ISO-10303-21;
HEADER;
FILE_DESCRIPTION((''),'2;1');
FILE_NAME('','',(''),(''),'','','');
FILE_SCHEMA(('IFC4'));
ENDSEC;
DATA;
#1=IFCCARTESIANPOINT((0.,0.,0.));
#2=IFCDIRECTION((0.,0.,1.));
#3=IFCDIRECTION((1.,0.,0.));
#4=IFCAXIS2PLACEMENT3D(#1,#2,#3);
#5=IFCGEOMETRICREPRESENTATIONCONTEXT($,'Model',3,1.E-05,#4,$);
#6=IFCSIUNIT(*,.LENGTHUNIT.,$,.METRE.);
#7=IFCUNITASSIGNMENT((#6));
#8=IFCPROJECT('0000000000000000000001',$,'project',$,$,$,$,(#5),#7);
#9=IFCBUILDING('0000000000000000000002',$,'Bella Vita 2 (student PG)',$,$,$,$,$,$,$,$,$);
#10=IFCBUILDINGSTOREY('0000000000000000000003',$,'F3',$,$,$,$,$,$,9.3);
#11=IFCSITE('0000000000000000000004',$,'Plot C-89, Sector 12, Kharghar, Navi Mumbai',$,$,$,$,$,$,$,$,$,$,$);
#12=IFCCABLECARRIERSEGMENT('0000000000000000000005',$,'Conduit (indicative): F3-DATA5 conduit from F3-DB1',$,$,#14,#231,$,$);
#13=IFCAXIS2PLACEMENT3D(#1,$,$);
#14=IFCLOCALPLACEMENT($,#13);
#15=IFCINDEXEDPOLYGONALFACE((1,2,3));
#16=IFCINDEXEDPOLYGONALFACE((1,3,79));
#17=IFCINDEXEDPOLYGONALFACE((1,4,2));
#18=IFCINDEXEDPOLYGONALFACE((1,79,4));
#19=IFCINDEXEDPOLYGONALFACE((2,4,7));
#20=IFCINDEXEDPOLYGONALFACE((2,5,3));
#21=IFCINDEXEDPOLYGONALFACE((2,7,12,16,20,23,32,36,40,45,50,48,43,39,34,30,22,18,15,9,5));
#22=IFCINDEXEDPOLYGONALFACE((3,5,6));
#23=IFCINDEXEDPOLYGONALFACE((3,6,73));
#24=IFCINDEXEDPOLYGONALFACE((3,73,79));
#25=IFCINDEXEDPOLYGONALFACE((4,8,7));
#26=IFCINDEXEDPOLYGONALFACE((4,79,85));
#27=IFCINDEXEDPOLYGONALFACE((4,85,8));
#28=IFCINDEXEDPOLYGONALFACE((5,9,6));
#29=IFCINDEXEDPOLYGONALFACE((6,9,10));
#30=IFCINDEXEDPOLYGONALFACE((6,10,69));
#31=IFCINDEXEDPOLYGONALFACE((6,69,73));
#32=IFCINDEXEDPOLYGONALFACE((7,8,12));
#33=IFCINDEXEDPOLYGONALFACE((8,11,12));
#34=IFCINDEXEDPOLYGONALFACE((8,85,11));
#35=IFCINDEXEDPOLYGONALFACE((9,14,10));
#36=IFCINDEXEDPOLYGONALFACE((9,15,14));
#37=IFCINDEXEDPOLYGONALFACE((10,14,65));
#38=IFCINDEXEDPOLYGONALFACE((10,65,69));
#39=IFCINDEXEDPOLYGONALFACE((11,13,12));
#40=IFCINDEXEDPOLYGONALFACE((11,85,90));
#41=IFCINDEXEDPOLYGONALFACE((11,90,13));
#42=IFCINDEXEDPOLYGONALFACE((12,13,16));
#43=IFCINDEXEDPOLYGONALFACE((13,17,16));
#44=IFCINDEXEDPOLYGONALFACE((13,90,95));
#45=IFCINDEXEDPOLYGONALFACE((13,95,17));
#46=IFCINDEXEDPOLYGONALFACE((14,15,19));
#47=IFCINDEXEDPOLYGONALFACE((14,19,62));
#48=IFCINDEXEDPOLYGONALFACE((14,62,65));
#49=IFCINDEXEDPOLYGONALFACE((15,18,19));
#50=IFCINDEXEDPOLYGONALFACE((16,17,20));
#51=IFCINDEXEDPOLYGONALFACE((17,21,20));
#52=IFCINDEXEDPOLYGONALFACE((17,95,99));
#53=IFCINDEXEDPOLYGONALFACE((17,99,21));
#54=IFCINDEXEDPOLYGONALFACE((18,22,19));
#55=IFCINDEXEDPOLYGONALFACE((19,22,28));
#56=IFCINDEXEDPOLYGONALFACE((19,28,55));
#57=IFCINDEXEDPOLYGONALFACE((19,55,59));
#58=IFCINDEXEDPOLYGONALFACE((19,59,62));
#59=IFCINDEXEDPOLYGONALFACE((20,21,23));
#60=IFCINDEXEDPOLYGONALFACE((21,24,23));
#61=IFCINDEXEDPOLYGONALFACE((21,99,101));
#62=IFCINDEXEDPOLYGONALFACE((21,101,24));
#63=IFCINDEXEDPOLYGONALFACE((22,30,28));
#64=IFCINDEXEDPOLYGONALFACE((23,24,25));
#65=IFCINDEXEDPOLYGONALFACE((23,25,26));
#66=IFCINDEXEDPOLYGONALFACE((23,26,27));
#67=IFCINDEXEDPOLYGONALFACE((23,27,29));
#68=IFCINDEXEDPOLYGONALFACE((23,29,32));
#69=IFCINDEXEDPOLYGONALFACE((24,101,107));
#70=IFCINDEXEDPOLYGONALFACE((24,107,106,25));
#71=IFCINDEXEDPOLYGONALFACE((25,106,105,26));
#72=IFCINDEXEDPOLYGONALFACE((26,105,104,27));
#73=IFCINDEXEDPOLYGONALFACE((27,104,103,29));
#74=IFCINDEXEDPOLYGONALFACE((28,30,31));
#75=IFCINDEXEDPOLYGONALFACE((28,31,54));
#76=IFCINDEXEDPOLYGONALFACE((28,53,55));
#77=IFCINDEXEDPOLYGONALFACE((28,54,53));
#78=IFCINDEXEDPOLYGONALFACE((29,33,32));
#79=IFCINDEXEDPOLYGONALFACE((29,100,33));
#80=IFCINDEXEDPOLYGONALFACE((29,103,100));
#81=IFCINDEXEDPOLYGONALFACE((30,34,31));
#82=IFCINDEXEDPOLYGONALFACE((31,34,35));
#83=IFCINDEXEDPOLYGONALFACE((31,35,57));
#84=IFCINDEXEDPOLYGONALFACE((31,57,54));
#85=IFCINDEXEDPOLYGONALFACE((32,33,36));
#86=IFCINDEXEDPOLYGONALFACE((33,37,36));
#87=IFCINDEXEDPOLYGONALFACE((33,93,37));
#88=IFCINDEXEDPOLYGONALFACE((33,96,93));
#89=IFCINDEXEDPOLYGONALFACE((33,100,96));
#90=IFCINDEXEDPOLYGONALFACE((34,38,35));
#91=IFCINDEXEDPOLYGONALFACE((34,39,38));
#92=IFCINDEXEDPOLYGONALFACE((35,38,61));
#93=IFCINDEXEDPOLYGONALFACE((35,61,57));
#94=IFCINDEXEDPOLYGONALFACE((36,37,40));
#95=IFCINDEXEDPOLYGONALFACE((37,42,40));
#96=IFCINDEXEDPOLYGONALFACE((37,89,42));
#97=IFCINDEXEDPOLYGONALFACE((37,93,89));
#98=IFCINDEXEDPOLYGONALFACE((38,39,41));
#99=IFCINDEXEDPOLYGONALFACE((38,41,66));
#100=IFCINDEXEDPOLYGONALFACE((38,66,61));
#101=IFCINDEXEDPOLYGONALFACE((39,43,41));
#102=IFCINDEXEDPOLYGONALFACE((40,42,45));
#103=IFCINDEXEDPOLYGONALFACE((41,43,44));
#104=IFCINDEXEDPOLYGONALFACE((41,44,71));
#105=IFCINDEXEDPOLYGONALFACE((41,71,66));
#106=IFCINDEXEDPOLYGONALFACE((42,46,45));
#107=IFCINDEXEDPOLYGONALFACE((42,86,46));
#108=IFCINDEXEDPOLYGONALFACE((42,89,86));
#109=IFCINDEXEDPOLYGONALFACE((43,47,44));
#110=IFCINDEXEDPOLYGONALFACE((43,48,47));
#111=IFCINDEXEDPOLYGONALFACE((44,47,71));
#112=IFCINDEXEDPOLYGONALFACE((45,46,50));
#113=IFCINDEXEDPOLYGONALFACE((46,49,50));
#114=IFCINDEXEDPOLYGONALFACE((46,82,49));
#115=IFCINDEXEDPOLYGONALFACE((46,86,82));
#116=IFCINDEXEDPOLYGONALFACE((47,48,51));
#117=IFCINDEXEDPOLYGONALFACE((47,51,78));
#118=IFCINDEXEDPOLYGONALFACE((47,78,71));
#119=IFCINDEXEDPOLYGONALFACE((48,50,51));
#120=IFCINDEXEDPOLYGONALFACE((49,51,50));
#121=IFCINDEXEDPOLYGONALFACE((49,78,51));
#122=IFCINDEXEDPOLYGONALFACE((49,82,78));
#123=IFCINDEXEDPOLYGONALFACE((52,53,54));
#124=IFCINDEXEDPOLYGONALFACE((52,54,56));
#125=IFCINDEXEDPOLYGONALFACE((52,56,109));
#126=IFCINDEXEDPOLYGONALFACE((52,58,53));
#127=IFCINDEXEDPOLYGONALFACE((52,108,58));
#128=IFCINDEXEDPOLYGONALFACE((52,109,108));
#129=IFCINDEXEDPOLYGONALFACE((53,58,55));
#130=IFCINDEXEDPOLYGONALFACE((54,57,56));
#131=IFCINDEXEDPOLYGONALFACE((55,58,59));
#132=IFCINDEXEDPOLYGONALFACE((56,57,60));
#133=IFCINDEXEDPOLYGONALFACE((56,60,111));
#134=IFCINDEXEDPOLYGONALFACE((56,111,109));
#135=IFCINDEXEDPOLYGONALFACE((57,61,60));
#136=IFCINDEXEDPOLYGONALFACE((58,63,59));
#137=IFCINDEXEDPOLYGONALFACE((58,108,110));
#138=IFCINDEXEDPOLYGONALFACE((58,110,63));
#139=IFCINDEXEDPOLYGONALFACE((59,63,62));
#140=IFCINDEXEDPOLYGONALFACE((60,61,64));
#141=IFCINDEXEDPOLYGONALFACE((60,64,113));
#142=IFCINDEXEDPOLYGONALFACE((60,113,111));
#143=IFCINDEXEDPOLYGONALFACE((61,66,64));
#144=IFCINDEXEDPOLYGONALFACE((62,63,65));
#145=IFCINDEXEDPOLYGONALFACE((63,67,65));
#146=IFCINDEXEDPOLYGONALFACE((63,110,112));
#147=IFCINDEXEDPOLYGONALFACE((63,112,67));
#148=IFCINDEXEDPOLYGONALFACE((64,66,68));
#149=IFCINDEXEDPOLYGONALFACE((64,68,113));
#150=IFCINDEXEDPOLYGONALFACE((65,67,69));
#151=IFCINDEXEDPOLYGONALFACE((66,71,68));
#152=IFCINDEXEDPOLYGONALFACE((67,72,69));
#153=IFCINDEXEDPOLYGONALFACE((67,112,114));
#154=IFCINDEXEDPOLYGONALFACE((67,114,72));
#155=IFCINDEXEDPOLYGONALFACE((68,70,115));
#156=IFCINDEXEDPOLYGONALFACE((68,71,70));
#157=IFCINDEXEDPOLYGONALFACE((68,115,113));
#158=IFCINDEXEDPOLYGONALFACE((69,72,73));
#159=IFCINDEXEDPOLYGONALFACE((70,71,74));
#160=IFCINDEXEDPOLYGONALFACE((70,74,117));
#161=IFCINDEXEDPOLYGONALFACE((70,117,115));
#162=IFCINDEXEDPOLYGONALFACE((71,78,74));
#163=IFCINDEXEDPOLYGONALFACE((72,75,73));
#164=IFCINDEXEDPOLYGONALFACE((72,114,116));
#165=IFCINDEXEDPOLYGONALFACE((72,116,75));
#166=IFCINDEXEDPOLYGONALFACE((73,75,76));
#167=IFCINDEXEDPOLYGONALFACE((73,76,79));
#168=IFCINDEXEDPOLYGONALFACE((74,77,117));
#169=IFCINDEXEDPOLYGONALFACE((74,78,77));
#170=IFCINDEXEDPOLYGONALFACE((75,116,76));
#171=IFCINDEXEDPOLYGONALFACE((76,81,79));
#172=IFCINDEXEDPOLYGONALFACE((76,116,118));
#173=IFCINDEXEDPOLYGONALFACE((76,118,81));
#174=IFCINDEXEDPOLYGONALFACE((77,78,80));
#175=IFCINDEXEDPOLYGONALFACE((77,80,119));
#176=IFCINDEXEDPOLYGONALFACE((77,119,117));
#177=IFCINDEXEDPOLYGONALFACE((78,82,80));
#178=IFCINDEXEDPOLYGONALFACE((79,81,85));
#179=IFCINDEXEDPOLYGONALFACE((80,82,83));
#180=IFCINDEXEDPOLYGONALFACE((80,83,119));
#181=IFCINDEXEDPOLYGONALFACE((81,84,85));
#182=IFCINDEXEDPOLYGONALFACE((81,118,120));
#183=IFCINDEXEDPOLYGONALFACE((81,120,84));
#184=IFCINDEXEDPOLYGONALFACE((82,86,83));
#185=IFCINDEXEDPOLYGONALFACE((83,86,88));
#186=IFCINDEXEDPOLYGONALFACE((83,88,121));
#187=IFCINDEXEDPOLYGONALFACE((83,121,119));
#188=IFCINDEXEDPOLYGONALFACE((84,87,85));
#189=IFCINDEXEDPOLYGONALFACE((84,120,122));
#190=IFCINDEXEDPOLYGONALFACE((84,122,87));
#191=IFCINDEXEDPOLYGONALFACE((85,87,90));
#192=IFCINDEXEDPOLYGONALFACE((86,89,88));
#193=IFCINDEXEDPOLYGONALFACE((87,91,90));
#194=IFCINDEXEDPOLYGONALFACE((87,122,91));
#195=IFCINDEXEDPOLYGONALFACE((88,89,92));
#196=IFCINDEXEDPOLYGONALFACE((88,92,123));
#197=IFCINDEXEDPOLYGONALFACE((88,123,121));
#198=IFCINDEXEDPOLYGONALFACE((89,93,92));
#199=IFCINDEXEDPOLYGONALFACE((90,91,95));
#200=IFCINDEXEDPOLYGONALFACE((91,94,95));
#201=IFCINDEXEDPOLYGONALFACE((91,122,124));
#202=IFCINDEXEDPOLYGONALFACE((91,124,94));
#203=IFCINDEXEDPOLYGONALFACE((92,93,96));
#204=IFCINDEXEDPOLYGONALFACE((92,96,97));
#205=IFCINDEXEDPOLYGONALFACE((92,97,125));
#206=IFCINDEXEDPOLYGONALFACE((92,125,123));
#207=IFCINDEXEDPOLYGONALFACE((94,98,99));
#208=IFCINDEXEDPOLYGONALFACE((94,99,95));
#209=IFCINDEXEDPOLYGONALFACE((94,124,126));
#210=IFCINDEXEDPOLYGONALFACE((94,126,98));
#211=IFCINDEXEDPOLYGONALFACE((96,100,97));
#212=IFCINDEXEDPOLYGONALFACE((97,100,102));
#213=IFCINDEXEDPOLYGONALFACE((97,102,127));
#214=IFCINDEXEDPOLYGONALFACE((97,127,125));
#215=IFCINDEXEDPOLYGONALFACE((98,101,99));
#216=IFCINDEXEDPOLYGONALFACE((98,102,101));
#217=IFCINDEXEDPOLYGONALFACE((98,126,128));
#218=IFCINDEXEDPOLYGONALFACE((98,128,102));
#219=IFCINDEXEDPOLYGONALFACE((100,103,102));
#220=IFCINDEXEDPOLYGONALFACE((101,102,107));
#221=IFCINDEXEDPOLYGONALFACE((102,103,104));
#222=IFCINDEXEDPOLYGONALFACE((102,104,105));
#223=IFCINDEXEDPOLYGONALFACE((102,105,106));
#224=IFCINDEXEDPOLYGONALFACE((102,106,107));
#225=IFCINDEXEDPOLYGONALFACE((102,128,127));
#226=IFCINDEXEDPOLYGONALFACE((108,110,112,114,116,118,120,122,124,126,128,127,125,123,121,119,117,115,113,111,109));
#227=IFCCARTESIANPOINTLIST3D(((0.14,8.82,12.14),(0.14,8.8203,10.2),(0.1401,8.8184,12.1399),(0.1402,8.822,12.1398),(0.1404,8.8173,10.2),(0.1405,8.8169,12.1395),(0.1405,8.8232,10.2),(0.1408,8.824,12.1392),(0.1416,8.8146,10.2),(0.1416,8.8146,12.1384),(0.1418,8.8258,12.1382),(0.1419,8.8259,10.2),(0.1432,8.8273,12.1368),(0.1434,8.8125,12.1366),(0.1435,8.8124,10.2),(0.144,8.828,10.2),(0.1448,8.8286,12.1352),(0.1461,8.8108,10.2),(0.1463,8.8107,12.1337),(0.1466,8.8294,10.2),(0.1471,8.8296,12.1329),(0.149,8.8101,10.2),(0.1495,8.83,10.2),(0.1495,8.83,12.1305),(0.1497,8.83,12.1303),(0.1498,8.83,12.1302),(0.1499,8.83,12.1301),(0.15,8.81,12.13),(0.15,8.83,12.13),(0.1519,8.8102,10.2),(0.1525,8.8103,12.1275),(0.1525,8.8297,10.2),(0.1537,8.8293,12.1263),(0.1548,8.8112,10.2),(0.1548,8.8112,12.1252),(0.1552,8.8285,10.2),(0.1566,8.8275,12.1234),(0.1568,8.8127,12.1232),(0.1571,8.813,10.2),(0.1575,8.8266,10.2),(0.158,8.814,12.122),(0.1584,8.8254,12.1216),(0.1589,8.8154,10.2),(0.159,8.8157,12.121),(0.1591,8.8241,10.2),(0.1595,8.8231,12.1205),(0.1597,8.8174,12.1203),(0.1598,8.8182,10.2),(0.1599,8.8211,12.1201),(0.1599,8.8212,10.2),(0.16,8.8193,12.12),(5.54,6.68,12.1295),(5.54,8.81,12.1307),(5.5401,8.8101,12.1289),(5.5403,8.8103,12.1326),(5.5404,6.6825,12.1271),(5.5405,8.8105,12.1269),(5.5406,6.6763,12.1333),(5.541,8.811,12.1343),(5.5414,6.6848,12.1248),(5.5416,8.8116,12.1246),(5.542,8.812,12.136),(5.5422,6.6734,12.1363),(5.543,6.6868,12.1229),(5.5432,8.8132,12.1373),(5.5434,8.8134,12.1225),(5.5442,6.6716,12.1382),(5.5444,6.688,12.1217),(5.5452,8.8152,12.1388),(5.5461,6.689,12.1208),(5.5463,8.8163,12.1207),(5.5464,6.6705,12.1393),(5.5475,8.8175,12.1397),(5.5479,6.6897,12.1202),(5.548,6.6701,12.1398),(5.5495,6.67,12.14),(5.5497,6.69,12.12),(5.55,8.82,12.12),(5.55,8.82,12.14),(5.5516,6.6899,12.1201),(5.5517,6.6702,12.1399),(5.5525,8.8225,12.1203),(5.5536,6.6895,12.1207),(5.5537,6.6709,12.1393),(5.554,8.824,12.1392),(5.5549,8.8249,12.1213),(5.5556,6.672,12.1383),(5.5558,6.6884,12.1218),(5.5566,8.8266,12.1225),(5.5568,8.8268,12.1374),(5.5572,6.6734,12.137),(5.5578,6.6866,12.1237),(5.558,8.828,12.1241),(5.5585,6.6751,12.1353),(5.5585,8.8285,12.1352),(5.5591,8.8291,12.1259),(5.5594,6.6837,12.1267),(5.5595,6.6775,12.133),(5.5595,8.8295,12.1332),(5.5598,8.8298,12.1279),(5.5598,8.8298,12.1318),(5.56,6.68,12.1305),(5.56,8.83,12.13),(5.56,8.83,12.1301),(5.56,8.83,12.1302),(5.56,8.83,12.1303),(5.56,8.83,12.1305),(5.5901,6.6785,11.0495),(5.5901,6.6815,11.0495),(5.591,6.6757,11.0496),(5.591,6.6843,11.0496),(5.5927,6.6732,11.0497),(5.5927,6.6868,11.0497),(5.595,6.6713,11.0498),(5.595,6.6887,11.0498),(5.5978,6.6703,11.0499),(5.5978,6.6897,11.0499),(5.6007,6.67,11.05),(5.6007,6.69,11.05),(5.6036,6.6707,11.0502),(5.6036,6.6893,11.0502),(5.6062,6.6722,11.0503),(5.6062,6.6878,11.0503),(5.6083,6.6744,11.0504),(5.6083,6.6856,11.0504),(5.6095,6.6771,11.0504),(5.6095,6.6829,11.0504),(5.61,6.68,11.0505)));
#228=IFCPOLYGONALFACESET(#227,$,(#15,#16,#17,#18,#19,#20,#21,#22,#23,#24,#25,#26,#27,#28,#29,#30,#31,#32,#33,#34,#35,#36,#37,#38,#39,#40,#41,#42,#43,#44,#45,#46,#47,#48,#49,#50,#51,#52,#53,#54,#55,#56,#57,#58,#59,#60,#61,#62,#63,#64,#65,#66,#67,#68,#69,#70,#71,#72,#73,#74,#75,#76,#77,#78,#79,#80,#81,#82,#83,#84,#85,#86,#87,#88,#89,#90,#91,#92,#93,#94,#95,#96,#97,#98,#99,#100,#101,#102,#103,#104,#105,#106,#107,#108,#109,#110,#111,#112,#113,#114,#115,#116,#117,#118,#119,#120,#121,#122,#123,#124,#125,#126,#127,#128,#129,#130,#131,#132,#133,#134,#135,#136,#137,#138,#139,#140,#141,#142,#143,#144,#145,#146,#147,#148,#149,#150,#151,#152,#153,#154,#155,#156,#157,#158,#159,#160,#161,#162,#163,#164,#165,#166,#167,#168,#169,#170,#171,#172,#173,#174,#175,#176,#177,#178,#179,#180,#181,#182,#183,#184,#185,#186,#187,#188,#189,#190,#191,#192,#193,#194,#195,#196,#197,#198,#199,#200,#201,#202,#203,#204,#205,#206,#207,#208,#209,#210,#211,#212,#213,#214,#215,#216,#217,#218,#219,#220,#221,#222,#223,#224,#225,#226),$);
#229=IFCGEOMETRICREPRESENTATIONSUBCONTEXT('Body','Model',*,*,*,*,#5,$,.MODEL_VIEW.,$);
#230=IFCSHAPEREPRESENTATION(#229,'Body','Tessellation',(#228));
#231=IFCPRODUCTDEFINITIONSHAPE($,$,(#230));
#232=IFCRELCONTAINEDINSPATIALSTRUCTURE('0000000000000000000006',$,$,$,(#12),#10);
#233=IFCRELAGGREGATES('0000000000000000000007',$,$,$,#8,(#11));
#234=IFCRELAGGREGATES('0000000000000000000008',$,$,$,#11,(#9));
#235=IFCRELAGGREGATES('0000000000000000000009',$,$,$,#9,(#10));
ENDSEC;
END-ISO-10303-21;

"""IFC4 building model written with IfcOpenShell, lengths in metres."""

from ifc_helpers import new_model, entity, si_unit, origin, origin_with_axes, place, context, subcontext, project, spatial, element, save


model = new_model("IFC4")

# Units and contexts
model_context = context("Model", 3, precision=1e-05, world=origin_with_axes())
body_context = subcontext(model_context, "Body", "Model", "MODEL_VIEW")
ifc_project = project(units=[si_unit("LENGTHUNIT", "METRE")], contexts=[model_context])

# Site, building, storey
site = spatial("IfcSite", under=ifc_project, Name="Plot C-89, Sector 12, Kharghar, Navi Mumbai")
building = spatial("IfcBuilding", under=site, Name="Bella Vita 2 (student PG)")
storey = spatial("IfcBuildingStorey", under=building, Name="F3", Elevation=9.3)

# Cable carrier segment
cable_carrier_segment_1_placement = place(None, origin())
element("IfcCableCarrierSegment", 1, at=cable_carrier_segment_1_placement, inside=storey, Name="Conduit (indicative): F3-DATA5 conduit from F3-DB1", context=body_context, shape_type="AdvancedSweptSolid", body=[
    entity("IfcSweptDiskSolid", entity("IfcPolyline", [entity("IfcCartesianPoint", [5.6, 6.68, 11.05]), entity("IfcCartesianPoint", [5.55, 6.68, 12.13]), entity("IfcCartesianPoint", [5.55, 8.82, 12.13]), entity("IfcCartesianPoint", [0.15, 8.82, 12.13]), entity("IfcCartesianPoint", [0.15, 8.82, 10.2])]), 0.01),
])

save(model, "model.ifc")
